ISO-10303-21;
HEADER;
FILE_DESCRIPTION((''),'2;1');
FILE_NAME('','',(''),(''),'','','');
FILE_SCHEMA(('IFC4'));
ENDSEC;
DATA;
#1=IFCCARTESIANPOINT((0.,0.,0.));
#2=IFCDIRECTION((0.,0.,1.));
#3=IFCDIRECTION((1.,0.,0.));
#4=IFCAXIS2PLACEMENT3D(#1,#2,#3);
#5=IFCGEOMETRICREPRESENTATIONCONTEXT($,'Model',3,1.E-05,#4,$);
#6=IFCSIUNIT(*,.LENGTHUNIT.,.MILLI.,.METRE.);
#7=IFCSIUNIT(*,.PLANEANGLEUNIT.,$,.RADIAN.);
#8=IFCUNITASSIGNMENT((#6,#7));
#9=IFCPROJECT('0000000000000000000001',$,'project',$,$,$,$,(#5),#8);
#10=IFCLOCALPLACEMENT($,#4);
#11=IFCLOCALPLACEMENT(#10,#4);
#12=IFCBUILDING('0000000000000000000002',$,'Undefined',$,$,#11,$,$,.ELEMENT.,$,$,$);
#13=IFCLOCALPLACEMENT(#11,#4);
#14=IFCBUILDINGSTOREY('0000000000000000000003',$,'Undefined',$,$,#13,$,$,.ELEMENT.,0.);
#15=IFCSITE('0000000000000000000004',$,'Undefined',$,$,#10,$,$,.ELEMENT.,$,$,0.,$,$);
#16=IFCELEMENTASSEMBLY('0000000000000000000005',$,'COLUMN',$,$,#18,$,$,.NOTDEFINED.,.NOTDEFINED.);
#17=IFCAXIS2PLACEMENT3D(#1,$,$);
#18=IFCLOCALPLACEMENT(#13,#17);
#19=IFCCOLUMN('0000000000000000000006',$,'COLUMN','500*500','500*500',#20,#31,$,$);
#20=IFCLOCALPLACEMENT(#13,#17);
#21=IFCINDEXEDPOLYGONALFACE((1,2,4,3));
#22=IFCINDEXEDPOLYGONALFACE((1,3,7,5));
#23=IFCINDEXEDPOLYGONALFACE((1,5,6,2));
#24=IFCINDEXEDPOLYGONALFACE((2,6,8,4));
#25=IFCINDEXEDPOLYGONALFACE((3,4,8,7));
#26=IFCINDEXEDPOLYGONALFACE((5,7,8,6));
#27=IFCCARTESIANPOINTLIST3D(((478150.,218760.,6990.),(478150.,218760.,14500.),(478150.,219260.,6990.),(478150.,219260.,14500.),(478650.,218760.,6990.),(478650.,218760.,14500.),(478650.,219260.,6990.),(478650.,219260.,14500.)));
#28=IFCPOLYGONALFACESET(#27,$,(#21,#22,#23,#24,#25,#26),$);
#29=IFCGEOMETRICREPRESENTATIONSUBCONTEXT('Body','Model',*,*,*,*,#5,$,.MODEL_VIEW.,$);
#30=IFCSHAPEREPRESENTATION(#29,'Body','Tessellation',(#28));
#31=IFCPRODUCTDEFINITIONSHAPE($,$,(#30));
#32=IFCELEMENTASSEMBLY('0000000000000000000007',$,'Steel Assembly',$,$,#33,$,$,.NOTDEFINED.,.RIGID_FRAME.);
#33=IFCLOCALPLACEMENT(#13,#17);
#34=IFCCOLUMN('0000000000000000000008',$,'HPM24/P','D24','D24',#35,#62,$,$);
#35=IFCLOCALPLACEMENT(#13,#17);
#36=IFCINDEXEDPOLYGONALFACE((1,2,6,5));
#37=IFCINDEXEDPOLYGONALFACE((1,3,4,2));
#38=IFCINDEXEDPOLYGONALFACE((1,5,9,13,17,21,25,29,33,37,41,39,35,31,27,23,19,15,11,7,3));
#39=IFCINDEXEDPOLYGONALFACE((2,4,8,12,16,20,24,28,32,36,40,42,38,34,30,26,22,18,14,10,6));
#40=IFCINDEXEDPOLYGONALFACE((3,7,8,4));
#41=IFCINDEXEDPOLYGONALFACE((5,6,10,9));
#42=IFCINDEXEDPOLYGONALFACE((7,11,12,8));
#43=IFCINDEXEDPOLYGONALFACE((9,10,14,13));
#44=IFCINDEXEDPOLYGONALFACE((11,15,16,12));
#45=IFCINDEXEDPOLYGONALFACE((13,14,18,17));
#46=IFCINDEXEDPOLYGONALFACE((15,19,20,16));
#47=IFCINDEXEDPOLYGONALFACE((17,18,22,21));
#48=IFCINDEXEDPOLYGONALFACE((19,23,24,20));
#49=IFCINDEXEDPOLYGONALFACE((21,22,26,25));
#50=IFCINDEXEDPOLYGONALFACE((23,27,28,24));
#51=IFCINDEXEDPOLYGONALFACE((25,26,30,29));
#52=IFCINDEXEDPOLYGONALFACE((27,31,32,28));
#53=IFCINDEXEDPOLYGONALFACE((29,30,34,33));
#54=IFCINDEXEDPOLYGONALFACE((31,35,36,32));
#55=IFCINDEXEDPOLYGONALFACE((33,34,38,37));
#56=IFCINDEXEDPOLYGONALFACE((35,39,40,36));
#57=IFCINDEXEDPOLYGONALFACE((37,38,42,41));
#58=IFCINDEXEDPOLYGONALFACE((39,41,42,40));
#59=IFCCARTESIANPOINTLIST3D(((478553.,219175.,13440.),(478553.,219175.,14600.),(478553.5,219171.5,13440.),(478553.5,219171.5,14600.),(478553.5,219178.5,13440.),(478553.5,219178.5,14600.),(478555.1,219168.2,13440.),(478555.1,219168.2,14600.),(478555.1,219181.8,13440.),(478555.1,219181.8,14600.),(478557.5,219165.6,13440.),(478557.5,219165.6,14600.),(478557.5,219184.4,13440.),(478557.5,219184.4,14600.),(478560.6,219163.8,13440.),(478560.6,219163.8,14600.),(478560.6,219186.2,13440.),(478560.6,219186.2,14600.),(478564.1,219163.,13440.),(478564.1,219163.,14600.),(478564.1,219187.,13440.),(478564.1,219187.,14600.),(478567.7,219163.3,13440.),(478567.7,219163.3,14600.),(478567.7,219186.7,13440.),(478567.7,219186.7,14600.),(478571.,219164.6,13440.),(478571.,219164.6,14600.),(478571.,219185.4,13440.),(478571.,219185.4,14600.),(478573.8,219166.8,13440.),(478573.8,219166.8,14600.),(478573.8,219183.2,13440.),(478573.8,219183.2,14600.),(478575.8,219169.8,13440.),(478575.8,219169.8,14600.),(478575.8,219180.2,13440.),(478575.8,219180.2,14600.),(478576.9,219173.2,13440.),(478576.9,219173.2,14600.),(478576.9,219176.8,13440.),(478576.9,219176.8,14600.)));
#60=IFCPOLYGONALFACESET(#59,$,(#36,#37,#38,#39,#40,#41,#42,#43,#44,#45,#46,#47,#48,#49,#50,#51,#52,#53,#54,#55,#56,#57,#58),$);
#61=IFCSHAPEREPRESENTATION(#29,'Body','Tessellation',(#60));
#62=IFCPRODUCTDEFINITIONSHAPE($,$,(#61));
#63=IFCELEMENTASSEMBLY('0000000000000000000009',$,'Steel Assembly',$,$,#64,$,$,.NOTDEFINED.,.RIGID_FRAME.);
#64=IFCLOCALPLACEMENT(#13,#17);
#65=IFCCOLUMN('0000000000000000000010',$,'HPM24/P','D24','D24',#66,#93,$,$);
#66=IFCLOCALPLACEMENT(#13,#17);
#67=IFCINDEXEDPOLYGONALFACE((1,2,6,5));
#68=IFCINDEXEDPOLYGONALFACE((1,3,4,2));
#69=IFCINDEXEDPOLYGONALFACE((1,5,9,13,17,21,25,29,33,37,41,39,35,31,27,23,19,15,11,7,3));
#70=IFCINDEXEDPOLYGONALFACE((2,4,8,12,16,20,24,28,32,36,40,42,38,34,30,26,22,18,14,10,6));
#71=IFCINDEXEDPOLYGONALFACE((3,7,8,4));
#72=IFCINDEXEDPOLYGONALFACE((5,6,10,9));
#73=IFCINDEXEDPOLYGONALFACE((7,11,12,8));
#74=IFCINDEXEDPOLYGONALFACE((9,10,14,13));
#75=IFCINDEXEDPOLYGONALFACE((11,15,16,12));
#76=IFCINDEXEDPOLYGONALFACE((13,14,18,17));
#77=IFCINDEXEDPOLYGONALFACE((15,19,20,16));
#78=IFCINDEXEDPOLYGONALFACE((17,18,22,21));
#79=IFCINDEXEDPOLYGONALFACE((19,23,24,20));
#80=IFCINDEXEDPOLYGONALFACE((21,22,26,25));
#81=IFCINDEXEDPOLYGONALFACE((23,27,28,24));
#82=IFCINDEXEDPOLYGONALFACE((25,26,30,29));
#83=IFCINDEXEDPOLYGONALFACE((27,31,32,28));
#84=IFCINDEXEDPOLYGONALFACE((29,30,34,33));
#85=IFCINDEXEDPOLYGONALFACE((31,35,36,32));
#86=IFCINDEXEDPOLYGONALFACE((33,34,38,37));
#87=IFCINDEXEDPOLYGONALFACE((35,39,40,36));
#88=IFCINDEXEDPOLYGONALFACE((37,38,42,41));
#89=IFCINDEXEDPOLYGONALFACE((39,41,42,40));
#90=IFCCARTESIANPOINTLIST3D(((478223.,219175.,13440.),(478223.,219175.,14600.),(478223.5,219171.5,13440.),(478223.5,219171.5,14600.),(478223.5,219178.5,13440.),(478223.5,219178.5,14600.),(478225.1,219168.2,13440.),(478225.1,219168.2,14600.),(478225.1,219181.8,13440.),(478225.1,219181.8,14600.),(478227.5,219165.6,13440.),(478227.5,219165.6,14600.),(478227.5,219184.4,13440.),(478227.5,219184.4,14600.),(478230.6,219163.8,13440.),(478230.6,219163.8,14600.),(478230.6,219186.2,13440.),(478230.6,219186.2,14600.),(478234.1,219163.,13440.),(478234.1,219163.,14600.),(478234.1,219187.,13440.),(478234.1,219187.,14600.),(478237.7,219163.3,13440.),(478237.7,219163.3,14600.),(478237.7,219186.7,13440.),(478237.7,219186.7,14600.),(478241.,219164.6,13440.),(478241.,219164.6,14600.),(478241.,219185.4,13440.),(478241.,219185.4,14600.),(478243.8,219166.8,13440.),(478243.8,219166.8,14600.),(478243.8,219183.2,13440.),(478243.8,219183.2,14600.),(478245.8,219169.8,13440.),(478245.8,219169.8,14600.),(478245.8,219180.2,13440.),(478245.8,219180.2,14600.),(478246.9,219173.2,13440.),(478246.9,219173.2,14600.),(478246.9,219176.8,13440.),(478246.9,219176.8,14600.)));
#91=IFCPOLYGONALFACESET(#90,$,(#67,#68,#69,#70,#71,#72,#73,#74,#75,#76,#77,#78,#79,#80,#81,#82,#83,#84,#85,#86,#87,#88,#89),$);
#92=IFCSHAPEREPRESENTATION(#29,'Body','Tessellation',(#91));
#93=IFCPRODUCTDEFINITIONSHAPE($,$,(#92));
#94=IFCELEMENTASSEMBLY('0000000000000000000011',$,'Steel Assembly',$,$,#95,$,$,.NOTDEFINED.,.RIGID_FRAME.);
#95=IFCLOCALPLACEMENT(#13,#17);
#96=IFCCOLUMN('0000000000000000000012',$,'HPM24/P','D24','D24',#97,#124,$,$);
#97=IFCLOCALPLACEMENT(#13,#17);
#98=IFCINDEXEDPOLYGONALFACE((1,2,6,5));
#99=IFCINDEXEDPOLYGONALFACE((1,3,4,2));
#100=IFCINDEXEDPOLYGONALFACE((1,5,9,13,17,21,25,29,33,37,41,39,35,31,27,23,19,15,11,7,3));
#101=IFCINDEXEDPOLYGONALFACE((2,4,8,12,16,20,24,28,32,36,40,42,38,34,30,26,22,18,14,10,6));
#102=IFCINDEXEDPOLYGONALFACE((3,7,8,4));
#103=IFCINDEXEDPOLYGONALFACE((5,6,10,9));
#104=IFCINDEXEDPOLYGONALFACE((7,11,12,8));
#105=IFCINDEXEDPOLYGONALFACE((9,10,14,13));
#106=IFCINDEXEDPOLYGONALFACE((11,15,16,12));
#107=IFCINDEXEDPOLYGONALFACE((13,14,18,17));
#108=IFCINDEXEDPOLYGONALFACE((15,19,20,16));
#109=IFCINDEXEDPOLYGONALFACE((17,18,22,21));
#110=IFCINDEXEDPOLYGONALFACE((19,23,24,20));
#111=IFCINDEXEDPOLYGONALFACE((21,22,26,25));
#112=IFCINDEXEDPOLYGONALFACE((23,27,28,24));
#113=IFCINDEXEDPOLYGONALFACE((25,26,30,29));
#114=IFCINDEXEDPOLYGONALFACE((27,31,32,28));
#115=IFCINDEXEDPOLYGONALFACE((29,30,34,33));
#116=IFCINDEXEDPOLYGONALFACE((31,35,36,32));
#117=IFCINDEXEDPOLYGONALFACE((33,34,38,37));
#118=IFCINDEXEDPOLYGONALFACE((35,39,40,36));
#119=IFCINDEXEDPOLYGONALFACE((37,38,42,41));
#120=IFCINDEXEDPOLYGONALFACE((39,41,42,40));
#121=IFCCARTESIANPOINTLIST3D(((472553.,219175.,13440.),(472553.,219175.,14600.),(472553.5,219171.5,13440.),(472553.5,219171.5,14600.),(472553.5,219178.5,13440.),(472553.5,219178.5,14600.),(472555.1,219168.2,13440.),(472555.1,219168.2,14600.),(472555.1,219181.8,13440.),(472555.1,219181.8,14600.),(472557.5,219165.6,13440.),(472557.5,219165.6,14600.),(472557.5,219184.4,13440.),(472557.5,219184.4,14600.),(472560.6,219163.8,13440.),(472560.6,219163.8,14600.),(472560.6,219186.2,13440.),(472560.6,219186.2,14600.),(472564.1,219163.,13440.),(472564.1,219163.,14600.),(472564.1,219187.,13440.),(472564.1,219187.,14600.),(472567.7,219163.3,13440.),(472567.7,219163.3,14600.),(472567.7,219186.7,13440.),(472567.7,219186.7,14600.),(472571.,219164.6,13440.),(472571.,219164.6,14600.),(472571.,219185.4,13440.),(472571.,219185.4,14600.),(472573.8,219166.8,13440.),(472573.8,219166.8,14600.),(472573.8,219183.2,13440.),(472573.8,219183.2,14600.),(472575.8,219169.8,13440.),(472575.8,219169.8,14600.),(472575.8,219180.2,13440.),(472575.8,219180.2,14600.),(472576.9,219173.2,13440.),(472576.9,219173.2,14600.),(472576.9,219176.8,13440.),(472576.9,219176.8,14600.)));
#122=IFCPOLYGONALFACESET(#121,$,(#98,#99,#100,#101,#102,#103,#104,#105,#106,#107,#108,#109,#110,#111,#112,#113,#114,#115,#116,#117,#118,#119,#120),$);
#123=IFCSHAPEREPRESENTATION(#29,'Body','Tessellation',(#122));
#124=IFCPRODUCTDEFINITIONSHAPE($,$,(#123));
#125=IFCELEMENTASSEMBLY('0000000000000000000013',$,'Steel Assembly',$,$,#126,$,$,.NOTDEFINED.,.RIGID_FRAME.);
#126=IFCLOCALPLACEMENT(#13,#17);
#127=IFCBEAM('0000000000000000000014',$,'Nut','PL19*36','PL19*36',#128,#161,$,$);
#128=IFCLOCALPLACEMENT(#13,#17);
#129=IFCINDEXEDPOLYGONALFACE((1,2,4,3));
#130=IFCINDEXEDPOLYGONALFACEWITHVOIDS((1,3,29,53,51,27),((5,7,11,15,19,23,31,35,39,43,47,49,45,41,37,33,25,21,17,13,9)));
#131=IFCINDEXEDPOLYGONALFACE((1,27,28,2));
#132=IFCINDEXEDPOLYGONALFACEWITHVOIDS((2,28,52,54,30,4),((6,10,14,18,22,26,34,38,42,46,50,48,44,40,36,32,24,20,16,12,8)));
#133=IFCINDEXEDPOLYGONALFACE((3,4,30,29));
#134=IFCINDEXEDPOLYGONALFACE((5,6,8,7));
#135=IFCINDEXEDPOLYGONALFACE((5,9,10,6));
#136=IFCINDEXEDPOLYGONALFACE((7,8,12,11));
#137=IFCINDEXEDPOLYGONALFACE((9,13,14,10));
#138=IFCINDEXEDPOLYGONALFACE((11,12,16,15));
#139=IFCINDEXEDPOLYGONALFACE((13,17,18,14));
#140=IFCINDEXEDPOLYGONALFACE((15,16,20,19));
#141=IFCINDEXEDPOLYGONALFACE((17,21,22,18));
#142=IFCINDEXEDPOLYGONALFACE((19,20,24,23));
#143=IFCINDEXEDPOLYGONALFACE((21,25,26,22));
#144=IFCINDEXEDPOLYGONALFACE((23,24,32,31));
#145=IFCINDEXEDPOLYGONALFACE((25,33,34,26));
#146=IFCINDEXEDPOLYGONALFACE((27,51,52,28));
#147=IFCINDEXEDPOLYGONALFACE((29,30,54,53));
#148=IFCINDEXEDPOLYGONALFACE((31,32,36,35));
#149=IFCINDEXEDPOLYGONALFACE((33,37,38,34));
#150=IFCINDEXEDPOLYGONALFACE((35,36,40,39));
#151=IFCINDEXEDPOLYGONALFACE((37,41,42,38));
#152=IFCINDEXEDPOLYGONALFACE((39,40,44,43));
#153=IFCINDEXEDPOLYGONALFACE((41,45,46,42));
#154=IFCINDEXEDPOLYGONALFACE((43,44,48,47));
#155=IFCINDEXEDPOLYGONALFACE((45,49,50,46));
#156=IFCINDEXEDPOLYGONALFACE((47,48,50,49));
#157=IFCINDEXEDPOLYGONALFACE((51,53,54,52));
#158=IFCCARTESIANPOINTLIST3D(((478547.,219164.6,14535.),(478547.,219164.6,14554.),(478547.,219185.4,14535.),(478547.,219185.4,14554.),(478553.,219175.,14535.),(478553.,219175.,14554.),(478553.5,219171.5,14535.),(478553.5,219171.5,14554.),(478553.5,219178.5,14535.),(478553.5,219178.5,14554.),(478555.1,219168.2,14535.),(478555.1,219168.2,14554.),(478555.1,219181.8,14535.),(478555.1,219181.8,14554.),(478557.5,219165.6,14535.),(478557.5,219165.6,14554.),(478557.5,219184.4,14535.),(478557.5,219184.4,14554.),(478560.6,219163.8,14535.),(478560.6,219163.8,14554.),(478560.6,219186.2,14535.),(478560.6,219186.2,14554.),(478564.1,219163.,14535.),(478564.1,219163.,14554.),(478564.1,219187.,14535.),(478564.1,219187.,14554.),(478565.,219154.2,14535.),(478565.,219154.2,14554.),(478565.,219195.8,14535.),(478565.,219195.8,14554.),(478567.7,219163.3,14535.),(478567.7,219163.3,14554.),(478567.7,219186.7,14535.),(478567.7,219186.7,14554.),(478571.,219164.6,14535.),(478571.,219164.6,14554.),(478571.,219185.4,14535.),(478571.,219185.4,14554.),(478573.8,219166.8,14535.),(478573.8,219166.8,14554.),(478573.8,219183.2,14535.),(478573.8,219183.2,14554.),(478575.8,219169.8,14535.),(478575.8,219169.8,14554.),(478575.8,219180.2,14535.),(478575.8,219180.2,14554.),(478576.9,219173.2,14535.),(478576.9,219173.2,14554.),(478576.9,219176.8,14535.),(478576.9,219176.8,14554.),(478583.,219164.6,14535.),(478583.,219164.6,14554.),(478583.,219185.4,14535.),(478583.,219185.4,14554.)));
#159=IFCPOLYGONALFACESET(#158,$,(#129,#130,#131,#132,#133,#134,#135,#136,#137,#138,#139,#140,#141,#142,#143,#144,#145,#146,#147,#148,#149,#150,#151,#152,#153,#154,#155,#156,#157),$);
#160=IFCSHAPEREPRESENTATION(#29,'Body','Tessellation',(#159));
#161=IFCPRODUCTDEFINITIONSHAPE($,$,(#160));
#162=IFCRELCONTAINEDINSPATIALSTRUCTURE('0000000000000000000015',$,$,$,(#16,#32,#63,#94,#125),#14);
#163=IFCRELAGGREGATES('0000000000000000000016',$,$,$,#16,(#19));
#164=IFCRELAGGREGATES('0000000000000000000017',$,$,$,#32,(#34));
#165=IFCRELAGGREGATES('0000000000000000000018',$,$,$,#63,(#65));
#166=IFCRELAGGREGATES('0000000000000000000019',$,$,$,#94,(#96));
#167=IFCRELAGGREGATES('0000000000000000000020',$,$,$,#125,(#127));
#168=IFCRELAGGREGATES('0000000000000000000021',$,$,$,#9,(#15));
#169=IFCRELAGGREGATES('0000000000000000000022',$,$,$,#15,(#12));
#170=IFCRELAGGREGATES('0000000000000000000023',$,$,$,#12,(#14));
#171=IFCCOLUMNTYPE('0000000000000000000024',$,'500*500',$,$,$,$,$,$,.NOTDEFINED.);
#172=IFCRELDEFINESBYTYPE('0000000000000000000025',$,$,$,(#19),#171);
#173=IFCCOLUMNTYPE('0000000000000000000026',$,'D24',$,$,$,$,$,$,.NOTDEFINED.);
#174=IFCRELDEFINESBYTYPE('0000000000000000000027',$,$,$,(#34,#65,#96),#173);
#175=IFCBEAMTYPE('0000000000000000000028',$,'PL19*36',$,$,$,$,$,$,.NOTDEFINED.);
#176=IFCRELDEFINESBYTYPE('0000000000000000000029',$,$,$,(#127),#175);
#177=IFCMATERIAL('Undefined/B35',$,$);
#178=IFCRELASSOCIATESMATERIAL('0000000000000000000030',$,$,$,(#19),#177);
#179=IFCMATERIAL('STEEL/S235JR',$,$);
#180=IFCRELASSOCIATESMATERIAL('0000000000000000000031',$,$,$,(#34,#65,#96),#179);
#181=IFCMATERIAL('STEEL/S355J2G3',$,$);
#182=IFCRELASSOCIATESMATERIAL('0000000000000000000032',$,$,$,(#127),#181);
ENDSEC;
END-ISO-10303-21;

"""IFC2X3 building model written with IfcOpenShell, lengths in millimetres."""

from ifc_helpers import new_model, si_unit, frame, origin_with_axes, origin_2d_with_axis, place, context, subcontext, project, spatial, rectangle, circle, extrude, boolean, halfspace, material, type_object, element, aggregate, save


model = new_model("IFC2X3")

# Units and contexts
model_context = context("Model", 3, precision=1e-05, world=origin_with_axes())
body_context = subcontext(model_context, "Body", "Model", "MODEL_VIEW")
ifc_project = project(units=[si_unit("LENGTHUNIT", "METRE", prefix="MILLI"), si_unit("PLANEANGLEUNIT", "RADIAN")], contexts=[model_context])

# Site, building, storey
site_placement = place(None, origin_with_axes())
site = spatial("IfcSite", under=ifc_project, at=site_placement, Name="Undefined", CompositionType="ELEMENT", RefElevation=0.0)
building_placement = place(site_placement, origin_with_axes())
building = spatial("IfcBuilding", under=site, at=building_placement, Name="Undefined", CompositionType="ELEMENT")
storey_placement = place(building_placement, origin_with_axes())
storey = spatial("IfcBuildingStorey", under=building, at=storey_placement, Name="Undefined", CompositionType="ELEMENT", Elevation=0.0)

# Element assemblies, columns
assembly_1_placement = place(storey_placement, origin_with_axes())
assembly_1 = element("IfcElementAssembly", 1, at=assembly_1_placement, inside=storey, Name="COLUMN", AssemblyPlace="NOTDEFINED", PredefinedType="NOTDEFINED")
ifc_material_1 = material(Name="Undefined/B35")
column_type_1 = type_object("IfcColumnType", Name="500*500", PredefinedType="NOTDEFINED")
column_1_placement = place(assembly_1_placement, frame((478400.0, 219010.0, 6990.0), z_axis=(0.0, 0.0, 1.0), x_axis=(1.0, 0.0, 0.0)))
column_1 = element("IfcColumn", 2, at=column_1_placement, type_object=column_type_1, material=ifc_material_1, Name="COLUMN", Description="500*500", ObjectType="500*500", context=body_context, shape_type="SweptSolid", body=[
    extrude(rectangle(XDim=500.0, YDim=500.0, at=origin_2d_with_axis()), frame((0.0, 0.0, 7510.0), z_axis=(0.0, 0.0, -1.0), x_axis=(-1.0, 0.0, 0.0)), (0.0, 0.0, 1.0), 7510.0),
])
aggregate(assembly_1, [column_1])
assembly_2_placement = place(storey_placement, origin_with_axes())
assembly_2 = element("IfcElementAssembly", 3, at=assembly_2_placement, inside=storey, Name="Steel Assembly", AssemblyPlace="NOTDEFINED", PredefinedType="RIGID_FRAME")
ifc_material_2 = material(Name="STEEL/S235JR")
column_type_2 = type_object("IfcColumnType", Name="D24", PredefinedType="NOTDEFINED")
column_2_placement = place(assembly_2_placement, frame((478565.0, 219175.0, 13440.0), z_axis=(0.0, 0.0, 1.0), x_axis=(1.0, 0.0, 0.0)))
column_2 = element("IfcColumn", 4, at=column_2_placement, type_object=column_type_2, material=ifc_material_2, Name="HPM24/P", Description="D24", ObjectType="D24", context=body_context, shape_type="SweptSolid", body=[
    extrude(circle(Radius=12.0, at=origin_2d_with_axis()), frame((0.0, 0.0, 1160.0), z_axis=(0.0, 0.0, -1.0), x_axis=(-1.0, 0.0, 0.0)), (0.0, 0.0, 1.0), 1160.0),
])
aggregate(assembly_2, [column_2])
assembly_3_placement = place(storey_placement, origin_with_axes())
assembly_3 = element("IfcElementAssembly", 5, at=assembly_3_placement, inside=storey, Name="Steel Assembly", AssemblyPlace="NOTDEFINED", PredefinedType="RIGID_FRAME")
column_3_placement = place(assembly_3_placement, frame((478235.0, 219175.0, 13440.0), z_axis=(0.0, 0.0, 1.0), x_axis=(1.0, 0.0, 0.0)))
column_3 = element("IfcColumn", 6, at=column_3_placement, type_object=column_type_2, material=ifc_material_2, Name="HPM24/P", Description="D24", ObjectType="D24", context=body_context, shape_type="SweptSolid", body=[
    extrude(circle(Radius=12.0, at=origin_2d_with_axis()), frame((0.0, 0.0, 1160.0), z_axis=(0.0, 0.0, -1.0), x_axis=(-1.0, 0.0, 0.0)), (0.0, 0.0, 1.0), 1160.0),
])
aggregate(assembly_3, [column_3])
assembly_4_placement = place(storey_placement, origin_with_axes())
assembly_4 = element("IfcElementAssembly", 7, at=assembly_4_placement, inside=storey, Name="Steel Assembly", AssemblyPlace="NOTDEFINED", PredefinedType="RIGID_FRAME")
column_4_placement = place(assembly_4_placement, frame((472565.0, 219175.0, 13440.0), z_axis=(0.0, 0.0, 1.0), x_axis=(1.0, 0.0, 0.0)))
column_4 = element("IfcColumn", 8, at=column_4_placement, type_object=column_type_2, material=ifc_material_2, Name="HPM24/P", Description="D24", ObjectType="D24", context=body_context, shape_type="SweptSolid", body=[
    extrude(circle(Radius=12.0, at=origin_2d_with_axis()), frame((0.0, 0.0, 1160.0), z_axis=(0.0, 0.0, -1.0), x_axis=(-1.0, 0.0, 0.0)), (0.0, 0.0, 1.0), 1160.0),
])
aggregate(assembly_4, [column_4])

# Element assembly, beam
assembly_5_placement = place(storey_placement, origin_with_axes())
assembly_5 = element("IfcElementAssembly", 9, at=assembly_5_placement, inside=storey, Name="Steel Assembly", AssemblyPlace="NOTDEFINED", PredefinedType="RIGID_FRAME")
ifc_material_3 = material(Name="STEEL/S355J2G3")
beam_type_1 = type_object("IfcBeamType", Name="PL19*36", PredefinedType="NOTDEFINED")
beam_1_placement = place(assembly_5_placement, frame((478565.0, 219195.8, 14544.5), z_axis=(-1.0, 0.0, 0.0), x_axis=(0.0, -1.0, 0.0)))
beam_1 = element("IfcBeam", 10, at=beam_1_placement, type_object=beam_type_1, material=ifc_material_3, Name="Nut", Description="PL19*36", ObjectType="PL19*36", context=body_context, shape_type="CSG", body=[
    boolean("DIFFERENCE", boolean("DIFFERENCE", boolean("DIFFERENCE", boolean("DIFFERENCE", boolean("DIFFERENCE", extrude(rectangle(XDim=19.0, YDim=36.0, at=origin_2d_with_axis()), frame((41.6, 0.0, 0.0), z_axis=(-1.0, 0.0, 0.0), x_axis=(0.0, -1.0, 0.0)), (0.0, 0.0, 1.0), 41.6), extrude(circle(Radius=12.0, at=origin_2d_with_axis()), frame((20.8, -9.5, 0.0), z_axis=(0.0, 1.0, 0.0), x_axis=(0.0, 0.0, 1.0)), (0.0, 0.0, 1.0), 19.0)), halfspace(frame((31.2, -9.5, -18.0), z_axis=(0.865865, 0.0, -0.500278), x_axis=(0.500278, 0.0, 0.865865)), False)), halfspace(frame((52.0, -9.5, -18.0), z_axis=(0.865865, 0.0, 0.500278), x_axis=(-0.500278, 0.0, 0.865865)), False)), halfspace(frame((-10.4, 9.5, -18.0), z_axis=(-0.865865, 0.0, 0.500278), x_axis=(0.500278, 0.0, 0.865865)), False)), halfspace(frame((10.4, 9.5, -18.0), z_axis=(-0.865865, 0.0, -0.500278), x_axis=(-0.500278, 0.0, 0.865865)), False)),
])
aggregate(assembly_5, [beam_1])

save(model, "model.ifc")
